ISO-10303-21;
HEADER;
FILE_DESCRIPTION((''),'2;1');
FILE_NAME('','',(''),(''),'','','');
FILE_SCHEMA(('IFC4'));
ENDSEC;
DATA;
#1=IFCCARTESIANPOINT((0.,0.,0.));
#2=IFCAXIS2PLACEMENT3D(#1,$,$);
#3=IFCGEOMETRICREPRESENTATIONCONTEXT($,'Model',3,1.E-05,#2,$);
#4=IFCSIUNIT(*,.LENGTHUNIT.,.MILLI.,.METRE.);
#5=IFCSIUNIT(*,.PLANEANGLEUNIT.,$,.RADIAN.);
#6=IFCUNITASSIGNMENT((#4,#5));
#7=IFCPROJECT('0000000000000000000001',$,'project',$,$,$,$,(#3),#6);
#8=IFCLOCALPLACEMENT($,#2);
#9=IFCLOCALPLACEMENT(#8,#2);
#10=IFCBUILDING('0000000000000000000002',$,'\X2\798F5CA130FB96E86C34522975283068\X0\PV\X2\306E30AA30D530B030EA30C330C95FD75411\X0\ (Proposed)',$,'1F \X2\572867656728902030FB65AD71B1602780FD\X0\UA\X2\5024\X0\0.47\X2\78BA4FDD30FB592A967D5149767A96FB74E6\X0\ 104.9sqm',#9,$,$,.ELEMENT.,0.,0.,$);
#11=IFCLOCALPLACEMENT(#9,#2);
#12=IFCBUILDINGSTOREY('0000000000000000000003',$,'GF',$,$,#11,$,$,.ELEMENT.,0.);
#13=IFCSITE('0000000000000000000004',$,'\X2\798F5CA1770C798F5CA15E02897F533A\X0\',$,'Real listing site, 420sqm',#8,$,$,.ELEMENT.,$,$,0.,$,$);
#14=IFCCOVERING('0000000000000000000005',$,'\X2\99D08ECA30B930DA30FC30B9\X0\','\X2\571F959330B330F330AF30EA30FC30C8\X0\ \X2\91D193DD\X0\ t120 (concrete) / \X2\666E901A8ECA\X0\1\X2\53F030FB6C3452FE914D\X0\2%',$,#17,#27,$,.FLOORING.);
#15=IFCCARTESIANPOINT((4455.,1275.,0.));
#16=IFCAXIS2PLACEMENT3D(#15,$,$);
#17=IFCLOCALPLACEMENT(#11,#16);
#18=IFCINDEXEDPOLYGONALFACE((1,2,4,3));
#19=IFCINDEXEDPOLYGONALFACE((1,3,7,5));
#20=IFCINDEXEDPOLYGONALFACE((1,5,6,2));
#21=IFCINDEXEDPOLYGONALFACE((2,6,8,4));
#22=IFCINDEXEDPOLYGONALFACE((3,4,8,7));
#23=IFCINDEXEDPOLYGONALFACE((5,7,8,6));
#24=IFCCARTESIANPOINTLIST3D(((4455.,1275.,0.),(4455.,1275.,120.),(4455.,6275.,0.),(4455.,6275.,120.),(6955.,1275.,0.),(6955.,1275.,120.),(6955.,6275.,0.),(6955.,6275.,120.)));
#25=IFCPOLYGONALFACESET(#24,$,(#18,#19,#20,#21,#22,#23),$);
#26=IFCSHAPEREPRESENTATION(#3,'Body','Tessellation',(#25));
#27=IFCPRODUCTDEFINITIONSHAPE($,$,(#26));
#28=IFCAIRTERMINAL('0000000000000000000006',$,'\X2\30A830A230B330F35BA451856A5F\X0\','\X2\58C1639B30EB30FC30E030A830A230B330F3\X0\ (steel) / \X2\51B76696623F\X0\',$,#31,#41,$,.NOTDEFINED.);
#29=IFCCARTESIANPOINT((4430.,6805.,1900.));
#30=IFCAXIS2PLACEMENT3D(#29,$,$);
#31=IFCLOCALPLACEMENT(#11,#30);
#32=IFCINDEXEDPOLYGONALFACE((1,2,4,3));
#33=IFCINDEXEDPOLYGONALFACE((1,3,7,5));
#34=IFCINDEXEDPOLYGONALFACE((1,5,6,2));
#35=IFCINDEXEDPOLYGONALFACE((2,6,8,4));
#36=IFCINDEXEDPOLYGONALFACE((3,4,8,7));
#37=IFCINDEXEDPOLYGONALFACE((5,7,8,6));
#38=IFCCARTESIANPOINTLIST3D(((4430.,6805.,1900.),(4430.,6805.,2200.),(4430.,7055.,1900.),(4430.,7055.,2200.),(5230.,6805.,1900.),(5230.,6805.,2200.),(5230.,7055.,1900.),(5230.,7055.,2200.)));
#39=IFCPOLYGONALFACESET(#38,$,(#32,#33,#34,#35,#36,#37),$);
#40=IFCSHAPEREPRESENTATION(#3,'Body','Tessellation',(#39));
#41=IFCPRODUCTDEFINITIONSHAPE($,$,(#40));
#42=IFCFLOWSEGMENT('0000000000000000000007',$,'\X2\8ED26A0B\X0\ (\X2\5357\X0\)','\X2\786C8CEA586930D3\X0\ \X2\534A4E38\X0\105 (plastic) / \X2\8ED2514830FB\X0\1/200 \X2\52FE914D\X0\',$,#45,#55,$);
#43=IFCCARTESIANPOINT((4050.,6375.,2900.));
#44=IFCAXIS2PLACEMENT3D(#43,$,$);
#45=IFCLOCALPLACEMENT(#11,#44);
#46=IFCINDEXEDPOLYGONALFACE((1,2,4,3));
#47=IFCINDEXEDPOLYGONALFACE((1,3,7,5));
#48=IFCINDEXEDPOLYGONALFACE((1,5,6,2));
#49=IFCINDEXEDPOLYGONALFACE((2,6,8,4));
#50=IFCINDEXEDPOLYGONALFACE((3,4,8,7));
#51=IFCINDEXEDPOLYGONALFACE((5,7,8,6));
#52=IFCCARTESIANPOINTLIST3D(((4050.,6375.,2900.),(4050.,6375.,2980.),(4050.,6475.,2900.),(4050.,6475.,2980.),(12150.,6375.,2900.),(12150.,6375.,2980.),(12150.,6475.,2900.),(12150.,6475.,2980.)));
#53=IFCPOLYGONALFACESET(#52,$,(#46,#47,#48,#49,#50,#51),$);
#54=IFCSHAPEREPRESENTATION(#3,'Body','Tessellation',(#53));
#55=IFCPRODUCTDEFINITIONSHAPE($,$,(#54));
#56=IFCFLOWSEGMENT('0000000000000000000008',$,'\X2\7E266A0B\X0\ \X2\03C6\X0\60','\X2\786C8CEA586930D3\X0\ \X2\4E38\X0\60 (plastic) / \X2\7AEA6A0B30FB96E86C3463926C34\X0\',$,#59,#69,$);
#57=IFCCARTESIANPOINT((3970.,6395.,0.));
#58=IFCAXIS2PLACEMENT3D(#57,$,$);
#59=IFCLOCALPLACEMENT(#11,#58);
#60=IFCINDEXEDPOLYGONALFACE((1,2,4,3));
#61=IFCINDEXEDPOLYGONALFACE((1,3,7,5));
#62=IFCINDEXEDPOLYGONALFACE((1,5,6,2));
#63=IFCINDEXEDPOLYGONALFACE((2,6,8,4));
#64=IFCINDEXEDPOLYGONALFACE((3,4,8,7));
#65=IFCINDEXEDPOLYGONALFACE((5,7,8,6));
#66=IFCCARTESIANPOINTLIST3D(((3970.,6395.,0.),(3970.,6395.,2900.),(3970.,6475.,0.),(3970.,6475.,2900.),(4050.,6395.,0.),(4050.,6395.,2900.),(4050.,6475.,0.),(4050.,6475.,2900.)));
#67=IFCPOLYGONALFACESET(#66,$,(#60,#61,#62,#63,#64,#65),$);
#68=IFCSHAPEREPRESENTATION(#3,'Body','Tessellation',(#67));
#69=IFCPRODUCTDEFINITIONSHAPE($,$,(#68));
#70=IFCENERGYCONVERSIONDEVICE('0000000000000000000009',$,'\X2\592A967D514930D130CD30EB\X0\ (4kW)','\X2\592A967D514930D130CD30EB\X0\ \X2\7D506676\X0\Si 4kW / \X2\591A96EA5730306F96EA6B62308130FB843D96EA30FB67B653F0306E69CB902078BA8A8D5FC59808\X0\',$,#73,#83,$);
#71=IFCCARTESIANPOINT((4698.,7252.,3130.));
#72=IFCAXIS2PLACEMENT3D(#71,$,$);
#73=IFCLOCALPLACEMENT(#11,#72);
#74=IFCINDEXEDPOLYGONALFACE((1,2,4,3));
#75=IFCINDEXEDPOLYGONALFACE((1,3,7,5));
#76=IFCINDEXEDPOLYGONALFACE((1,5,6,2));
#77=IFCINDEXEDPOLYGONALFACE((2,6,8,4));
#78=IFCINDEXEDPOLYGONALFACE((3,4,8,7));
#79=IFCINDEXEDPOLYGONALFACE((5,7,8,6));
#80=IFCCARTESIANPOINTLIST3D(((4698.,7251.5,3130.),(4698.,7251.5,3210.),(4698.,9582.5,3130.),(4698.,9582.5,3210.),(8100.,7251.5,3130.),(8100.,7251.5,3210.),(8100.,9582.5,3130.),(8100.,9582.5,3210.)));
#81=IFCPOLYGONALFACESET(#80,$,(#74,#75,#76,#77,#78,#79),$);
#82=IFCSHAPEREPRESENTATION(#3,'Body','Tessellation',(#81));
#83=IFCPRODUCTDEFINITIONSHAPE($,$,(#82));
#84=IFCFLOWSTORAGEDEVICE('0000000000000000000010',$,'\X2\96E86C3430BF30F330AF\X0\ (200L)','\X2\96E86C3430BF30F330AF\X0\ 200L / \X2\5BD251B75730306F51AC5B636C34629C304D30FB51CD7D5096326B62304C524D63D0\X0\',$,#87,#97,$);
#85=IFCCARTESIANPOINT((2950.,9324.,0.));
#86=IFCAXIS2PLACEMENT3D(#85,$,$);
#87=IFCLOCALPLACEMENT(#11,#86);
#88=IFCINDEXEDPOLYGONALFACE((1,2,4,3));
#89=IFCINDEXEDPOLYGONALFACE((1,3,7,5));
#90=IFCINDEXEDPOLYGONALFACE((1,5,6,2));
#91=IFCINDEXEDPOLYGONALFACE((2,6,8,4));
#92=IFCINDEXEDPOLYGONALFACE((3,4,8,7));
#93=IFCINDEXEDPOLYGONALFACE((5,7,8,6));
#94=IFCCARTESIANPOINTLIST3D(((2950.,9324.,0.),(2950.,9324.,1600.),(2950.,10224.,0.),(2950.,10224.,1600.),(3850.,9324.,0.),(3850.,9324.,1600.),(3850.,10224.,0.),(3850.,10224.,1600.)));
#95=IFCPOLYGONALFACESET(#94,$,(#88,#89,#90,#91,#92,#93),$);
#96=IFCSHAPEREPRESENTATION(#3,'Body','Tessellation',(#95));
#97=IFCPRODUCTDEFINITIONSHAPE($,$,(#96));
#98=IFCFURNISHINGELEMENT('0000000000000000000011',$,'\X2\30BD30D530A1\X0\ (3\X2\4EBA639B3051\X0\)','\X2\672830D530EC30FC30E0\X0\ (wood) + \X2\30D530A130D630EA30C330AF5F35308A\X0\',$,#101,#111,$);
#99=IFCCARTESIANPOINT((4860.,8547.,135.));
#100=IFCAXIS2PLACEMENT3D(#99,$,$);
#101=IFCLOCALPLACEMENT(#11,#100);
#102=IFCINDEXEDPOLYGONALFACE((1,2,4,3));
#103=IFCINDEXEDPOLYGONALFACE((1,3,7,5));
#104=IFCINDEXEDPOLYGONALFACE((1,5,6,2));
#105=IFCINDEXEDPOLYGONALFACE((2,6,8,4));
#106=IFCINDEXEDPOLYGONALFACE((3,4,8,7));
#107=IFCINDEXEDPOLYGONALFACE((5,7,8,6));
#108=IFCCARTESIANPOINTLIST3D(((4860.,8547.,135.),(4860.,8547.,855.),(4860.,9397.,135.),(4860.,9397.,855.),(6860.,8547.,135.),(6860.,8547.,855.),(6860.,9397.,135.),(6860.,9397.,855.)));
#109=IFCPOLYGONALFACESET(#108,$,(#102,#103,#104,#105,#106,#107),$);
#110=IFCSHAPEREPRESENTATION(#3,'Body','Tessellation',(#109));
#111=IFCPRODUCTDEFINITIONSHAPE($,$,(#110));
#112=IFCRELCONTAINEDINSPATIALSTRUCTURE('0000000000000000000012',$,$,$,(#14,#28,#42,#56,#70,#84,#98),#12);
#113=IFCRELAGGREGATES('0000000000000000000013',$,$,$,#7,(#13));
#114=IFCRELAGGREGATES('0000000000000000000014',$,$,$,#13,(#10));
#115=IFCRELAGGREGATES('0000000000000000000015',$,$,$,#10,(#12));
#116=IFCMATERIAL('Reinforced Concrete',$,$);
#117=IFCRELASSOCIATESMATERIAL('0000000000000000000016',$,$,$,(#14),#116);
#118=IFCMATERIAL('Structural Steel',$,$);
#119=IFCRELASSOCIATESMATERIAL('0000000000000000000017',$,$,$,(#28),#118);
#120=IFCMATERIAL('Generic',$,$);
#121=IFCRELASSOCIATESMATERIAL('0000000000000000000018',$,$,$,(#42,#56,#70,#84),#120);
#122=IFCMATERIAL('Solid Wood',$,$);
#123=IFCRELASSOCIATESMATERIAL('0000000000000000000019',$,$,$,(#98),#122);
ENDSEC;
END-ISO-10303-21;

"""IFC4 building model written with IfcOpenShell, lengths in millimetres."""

from ifc_helpers import new_model, si_unit, frame, frame_2d, origin, place, context, project, spatial, rectangle, extrude, material, element, save


model = new_model("IFC4")

# Units and contexts
model_context = context("Model", 3, precision=1e-05, world=origin())
ifc_project = project(units=[si_unit("LENGTHUNIT", "METRE", prefix="MILLI"), si_unit("PLANEANGLEUNIT", "RADIAN")], contexts=[model_context])

# Site, building, storey
site_placement = place(None, origin())
site = spatial("IfcSite", under=ifc_project, at=site_placement, Name="福岡県福岡市西区", ObjectType="Real listing site, 420sqm", CompositionType="ELEMENT", RefElevation=0.0)
building_placement = place(site_placement, origin())
building = spatial("IfcBuilding", under=site, at=building_placement, Name="福岡・雨水利用とPVのオフグリッド志向 (Proposed)", ObjectType="1F 在来木造・断熱性能UA値0.47確保・太陽光発電瓦 104.9sqm", CompositionType="ELEMENT", ElevationOfRefHeight=0.0, ElevationOfTerrain=0.0)
storey_placement = place(building_placement, origin())
storey = spatial("IfcBuildingStorey", under=building, at=storey_placement, Name="GF", CompositionType="ELEMENT", Elevation=0.0)

# Shared definitions
ifc_material_1 = material(Name="Solid Wood")

# Shared definitions
ifc_material_2 = material(Name="Reinforced Concrete")

# Shared definitions
ifc_material_3 = material(Name="Structural Steel")

# Covering
ifc_material_4 = material(Name="Generic")
covering_1_placement = place(storey_placement, frame((4455.0, 1275.0, 0.0)))
element("IfcCovering", 1, at=covering_1_placement, inside=storey, material=ifc_material_2, Name="駐車スペース", Description="土間コンクリート 金鏝 t120 (concrete) / 普通車1台・水勾配2%", PredefinedType="FLOORING", context=model_context, shape_type="SweptSolid", body=[
    extrude(rectangle(XDim=2500.0, YDim=5000.0, at=frame_2d((1250.0, 2500.0))), frame((4455.0, 1275.0, 0.0)), (0.0, 0.0, 1.0), 120.0),
])

# Air terminal
air_terminal_placement = place(storey_placement, frame((4430.0, 6805.0, 1900.0)))
element("IfcAirTerminal", 2, at=air_terminal_placement, inside=storey, material=ifc_material_3, Name="エアコン室内機", Description="壁掛ルームエアコン (steel) / 冷暖房", PredefinedType="NOTDEFINED", context=model_context, shape_type="SweptSolid", body=[
    extrude(rectangle(XDim=800.0, YDim=250.0, at=frame_2d((400.0, 125.0))), frame((4430.0, 6805.0, 1900.0)), (0.0, 0.0, 1.0), 300.0),
])

# Flow segments
flow_segment_1_placement = place(storey_placement, frame((4050.0, 6375.0, 2900.0)))
element("IfcFlowSegment", 3, at=flow_segment_1_placement, inside=storey, material=ifc_material_4, Name="軒樋 (南)", Description="硬質塩ビ 半丸105 (plastic) / 軒先・1/200 勾配", context=model_context, shape_type="SweptSolid", body=[
    extrude(rectangle(XDim=8100.0, YDim=100.0, at=frame_2d((4050.0, 50.0))), frame((4050.0, 6375.0, 2900.0)), (0.0, 0.0, 1.0), 80.0),
])
flow_segment_2_placement = place(storey_placement, frame((3970.0, 6395.0, 0.0)))
element("IfcFlowSegment", 4, at=flow_segment_2_placement, inside=storey, material=ifc_material_4, Name="縦樋 φ60", Description="硬質塩ビ 丸60 (plastic) / 竪樋・雨水排水", context=model_context, shape_type="SweptSolid", body=[
    extrude(rectangle(XDim=80.0, YDim=80.0, at=frame_2d((40.0, 40.0))), frame((3970.0, 6395.0, 0.0)), (0.0, 0.0, 1.0), 2900.0),
])

# Energy conversion device
energy_conversion_device_placement = place(storey_placement, frame((4698.0, 7252.0, 3130.0)))
element("IfcEnergyConversionDevice", 5, at=energy_conversion_device_placement, inside=storey, material=ifc_material_4, Name="太陽光パネル (4kW)", Description="太陽光パネル 結晶Si 4kW / 多雪地は雪止め・落雪・架台の構造確認必須", context=model_context, shape_type="SweptSolid", body=[
    extrude(rectangle(XDim=3402.0, YDim=2331.0, at=frame_2d((1701.0, 1165.0))), frame((4698.0, 7252.0, 3130.0)), (0.0, 0.0, 1.0), 80.0),
])

# Flow storage device
flow_storage_device_placement = place(storey_placement, frame((2950.0, 9324.0, 0.0)))
element("IfcFlowStorageDevice", 6, at=flow_storage_device_placement, inside=storey, material=ifc_material_4, Name="雨水タンク (200L)", Description="雨水タンク 200L / 寒冷地は冬季水抜き・凍結防止が前提", context=model_context, shape_type="SweptSolid", body=[
    extrude(rectangle(XDim=900.0, YDim=900.0, at=frame_2d((450.0, 450.0))), frame((2950.0, 9324.0, 0.0)), (0.0, 0.0, 1.0), 1600.0),
])

# Furnishing element
furnishing_placement = place(storey_placement, frame((4860.0, 8547.0, 135.0)))
element("IfcFurnishingElement", 7, at=furnishing_placement, inside=storey, material=ifc_material_1, Name="ソファ (3人掛け)", Description="木フレーム (wood) + ファブリック張り", context=model_context, shape_type="SweptSolid", body=[
    extrude(rectangle(XDim=2000.0, YDim=850.0, at=frame_2d((1000.0, 425.0))), frame((4860.0, 8547.0, 135.0)), (0.0, 0.0, 1.0), 720.0),
])

save(model, "model.ifc")
